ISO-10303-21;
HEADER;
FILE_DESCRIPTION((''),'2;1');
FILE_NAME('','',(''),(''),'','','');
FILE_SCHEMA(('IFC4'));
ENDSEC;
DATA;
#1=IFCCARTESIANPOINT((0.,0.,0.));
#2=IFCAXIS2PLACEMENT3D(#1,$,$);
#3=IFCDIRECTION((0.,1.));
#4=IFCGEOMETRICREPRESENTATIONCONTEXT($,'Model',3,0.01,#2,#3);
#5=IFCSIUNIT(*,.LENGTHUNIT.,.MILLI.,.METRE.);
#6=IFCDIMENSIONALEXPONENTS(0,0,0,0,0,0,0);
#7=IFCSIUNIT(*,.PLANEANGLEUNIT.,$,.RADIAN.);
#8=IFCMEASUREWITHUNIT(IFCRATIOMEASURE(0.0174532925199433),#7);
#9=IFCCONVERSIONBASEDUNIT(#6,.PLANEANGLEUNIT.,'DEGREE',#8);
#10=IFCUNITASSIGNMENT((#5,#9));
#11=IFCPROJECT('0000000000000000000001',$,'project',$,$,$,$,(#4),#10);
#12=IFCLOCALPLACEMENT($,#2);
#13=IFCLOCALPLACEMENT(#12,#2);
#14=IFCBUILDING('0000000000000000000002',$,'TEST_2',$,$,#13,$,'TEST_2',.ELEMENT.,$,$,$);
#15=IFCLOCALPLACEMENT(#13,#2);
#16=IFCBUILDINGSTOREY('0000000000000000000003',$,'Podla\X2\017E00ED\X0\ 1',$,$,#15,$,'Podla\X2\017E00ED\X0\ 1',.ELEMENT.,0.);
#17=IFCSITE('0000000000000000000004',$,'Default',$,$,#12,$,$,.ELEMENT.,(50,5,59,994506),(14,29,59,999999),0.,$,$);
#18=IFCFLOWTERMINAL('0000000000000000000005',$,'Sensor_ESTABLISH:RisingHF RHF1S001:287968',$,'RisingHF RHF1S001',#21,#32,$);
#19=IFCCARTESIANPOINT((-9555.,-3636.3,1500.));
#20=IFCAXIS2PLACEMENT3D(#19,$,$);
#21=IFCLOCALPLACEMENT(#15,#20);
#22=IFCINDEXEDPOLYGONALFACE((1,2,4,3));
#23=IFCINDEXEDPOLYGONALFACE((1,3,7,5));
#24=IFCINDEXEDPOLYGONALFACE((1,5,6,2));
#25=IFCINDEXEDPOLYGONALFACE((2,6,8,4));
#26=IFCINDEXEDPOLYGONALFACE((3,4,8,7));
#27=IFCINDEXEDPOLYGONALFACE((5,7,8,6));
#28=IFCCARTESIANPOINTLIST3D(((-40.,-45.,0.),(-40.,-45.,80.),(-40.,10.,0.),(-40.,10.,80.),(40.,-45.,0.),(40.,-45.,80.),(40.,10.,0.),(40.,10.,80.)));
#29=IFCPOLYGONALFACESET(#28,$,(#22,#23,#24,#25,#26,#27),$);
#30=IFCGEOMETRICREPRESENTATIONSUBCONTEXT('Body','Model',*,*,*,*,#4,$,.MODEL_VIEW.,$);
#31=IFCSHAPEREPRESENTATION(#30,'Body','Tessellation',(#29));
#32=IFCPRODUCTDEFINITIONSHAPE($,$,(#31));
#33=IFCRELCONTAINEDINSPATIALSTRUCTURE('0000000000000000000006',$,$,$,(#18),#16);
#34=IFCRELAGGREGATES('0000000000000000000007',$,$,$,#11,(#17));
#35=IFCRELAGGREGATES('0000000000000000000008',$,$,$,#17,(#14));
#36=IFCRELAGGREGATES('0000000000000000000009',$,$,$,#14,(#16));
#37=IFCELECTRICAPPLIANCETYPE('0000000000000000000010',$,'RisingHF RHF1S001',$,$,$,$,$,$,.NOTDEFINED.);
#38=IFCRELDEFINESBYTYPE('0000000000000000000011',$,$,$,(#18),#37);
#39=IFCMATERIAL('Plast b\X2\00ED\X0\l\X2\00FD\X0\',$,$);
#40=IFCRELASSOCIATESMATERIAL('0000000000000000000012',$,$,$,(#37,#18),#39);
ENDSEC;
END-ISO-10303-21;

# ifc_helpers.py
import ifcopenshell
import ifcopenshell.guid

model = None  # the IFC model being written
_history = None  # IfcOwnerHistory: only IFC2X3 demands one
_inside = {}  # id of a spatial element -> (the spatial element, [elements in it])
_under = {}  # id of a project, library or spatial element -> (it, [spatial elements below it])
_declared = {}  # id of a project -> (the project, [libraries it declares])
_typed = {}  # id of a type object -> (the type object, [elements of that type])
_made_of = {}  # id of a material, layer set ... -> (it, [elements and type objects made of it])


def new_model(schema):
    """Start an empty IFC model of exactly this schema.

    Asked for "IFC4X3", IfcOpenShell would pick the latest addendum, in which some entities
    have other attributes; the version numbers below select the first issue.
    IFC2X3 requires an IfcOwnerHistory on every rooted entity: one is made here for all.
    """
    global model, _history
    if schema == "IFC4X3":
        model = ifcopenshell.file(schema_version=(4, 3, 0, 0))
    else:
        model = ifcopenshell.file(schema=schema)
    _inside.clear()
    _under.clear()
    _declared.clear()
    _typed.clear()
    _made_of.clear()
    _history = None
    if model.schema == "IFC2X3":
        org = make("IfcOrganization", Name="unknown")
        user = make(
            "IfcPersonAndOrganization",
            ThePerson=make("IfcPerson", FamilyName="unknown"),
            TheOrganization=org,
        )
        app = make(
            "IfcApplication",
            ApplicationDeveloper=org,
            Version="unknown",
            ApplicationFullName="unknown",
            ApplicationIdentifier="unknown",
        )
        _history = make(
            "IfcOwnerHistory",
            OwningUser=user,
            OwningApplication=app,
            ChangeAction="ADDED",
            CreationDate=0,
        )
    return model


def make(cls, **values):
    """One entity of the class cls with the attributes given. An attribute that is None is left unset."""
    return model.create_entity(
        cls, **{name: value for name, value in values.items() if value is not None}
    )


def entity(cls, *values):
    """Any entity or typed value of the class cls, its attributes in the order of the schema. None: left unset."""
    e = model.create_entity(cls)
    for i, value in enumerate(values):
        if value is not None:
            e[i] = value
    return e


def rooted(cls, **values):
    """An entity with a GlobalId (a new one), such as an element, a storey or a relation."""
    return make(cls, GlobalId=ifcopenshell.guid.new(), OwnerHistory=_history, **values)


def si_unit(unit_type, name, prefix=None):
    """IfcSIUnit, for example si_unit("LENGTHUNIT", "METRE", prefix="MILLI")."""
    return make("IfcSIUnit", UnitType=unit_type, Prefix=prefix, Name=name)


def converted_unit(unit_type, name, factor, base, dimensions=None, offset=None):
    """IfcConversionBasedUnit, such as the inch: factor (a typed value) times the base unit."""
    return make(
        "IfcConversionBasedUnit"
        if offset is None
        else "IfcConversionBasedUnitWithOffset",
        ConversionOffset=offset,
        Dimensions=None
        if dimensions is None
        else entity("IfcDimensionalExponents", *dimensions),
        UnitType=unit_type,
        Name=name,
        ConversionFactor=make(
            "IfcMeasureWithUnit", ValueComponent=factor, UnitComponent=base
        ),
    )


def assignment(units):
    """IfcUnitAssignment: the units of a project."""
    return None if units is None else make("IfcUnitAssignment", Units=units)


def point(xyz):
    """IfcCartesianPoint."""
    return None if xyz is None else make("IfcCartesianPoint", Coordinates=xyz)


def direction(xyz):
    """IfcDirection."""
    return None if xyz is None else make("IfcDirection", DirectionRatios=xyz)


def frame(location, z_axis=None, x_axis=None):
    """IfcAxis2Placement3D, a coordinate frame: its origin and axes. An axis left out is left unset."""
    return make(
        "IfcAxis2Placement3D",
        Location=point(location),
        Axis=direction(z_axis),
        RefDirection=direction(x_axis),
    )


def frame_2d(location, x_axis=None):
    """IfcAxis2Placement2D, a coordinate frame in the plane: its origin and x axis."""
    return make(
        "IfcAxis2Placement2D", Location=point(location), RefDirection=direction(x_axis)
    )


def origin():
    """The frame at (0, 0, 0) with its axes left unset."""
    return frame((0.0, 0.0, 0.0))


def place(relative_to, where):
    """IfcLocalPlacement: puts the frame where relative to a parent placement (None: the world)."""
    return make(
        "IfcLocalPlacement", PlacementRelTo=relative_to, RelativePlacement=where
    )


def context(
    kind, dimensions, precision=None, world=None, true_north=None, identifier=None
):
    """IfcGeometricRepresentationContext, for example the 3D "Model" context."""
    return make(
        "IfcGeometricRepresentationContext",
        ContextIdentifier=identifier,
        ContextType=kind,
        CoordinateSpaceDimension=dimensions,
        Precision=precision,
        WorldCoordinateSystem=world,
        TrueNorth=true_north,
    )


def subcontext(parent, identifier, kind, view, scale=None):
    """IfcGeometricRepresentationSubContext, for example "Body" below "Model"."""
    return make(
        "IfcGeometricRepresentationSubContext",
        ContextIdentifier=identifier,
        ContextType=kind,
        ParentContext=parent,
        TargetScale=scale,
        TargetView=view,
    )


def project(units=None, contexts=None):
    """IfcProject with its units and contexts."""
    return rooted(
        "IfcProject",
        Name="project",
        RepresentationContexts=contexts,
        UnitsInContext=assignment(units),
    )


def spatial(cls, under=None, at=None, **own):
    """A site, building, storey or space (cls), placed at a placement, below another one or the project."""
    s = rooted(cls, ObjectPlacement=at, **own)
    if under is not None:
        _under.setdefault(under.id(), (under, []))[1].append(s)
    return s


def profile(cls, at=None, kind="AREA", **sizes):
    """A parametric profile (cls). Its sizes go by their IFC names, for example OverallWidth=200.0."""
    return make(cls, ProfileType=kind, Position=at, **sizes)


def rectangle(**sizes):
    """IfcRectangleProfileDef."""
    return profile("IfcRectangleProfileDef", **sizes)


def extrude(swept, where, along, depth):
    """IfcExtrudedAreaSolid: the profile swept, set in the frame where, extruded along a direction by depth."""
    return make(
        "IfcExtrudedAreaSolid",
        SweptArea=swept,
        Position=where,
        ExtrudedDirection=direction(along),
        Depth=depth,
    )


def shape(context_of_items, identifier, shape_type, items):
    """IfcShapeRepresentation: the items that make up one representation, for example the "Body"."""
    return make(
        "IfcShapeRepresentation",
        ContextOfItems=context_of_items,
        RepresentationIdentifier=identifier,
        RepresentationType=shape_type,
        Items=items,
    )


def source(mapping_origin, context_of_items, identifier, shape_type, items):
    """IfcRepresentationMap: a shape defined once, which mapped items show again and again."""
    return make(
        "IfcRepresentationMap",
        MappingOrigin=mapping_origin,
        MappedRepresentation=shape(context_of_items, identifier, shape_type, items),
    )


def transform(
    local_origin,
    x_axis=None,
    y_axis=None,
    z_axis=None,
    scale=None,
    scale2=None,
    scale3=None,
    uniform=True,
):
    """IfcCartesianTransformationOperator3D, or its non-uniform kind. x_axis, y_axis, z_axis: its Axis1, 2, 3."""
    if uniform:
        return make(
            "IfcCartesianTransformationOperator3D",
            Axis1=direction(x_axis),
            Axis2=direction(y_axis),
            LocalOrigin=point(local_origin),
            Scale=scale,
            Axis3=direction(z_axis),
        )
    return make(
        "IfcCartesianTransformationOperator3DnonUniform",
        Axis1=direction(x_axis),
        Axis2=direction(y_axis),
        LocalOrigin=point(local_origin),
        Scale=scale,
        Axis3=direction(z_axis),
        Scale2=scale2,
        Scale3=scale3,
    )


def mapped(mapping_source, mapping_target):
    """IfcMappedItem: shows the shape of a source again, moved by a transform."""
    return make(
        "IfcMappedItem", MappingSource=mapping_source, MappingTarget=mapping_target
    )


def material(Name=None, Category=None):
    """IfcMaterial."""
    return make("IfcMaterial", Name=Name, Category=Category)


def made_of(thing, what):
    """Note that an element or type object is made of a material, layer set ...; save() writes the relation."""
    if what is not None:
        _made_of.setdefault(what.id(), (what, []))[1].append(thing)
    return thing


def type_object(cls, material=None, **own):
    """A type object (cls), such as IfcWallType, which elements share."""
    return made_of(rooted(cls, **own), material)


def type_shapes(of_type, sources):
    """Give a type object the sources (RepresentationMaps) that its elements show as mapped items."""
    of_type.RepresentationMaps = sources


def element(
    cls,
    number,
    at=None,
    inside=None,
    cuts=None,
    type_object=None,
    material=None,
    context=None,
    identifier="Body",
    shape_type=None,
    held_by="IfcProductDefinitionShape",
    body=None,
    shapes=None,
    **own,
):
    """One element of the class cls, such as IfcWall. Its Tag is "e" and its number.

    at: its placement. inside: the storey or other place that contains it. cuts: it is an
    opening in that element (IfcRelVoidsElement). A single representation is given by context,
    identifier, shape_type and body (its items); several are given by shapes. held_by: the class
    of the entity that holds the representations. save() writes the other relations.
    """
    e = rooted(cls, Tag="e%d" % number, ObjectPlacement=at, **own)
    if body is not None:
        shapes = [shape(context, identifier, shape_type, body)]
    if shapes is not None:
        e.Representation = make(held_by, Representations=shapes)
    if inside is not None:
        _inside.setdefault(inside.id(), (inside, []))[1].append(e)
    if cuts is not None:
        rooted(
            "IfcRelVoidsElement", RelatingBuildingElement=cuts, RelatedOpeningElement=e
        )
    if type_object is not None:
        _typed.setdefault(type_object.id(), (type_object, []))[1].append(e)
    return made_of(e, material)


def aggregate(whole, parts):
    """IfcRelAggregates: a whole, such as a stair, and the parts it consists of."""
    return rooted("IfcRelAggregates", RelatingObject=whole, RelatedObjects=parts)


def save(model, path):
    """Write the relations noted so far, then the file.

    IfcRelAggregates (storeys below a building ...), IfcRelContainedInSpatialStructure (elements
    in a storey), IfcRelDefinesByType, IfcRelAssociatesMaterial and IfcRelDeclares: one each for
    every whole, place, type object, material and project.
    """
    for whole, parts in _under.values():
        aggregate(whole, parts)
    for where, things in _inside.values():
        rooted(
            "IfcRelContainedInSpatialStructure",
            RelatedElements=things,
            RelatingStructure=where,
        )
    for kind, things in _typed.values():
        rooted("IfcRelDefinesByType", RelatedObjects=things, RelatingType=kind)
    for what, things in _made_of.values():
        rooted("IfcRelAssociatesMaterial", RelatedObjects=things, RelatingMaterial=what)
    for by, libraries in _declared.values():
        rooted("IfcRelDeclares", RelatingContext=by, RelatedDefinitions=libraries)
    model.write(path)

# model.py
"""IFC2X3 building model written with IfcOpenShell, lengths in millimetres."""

from ifc_helpers import new_model, entity, si_unit, converted_unit, direction, frame, frame_2d, origin, place, context, subcontext, project, spatial, rectangle, extrude, source, transform, mapped, material, type_object, type_shapes, element, save


model = new_model("IFC2X3")

# Units and contexts
model_context = context("Model", 3, precision=0.01, world=origin(), true_north=direction((0.0, 1.0)))
body_context = subcontext(model_context, "Body", "Model", "MODEL_VIEW")
ifc_project = project(units=[si_unit("LENGTHUNIT", "METRE", prefix="MILLI"), converted_unit("PLANEANGLEUNIT", "DEGREE", entity("IfcRatioMeasure", 0.0174532925199433), si_unit("PLANEANGLEUNIT", "RADIAN"), dimensions=[0, 0, 0, 0, 0, 0, 0])], contexts=[model_context])

# Site, building, storey
site_placement = place(None, origin())
site = spatial("IfcSite", under=ifc_project, at=site_placement, Name="Default", CompositionType="ELEMENT", RefLatitude=(50, 5, 59, 994506), RefLongitude=(14, 29, 59, 999999), RefElevation=0.0)
building_placement = place(site_placement, origin())
building = spatial("IfcBuilding", under=site, at=building_placement, Name="TEST_2", LongName="TEST_2", CompositionType="ELEMENT")
storey_placement = place(building_placement, origin())
storey = spatial("IfcBuildingStorey", under=building, at=storey_placement, Name="Podlaží 1", LongName="Podlaží 1", CompositionType="ELEMENT", Elevation=0.0)

# Flow terminal
ifc_material_1 = material(Name="Plast bílý")
electric_appliance_type_1 = type_object("IfcElectricApplianceType", Name="RisingHF RHF1S001", PredefinedType="NOTDEFINED", material=ifc_material_1)
shared_shape_1 = source(origin(), body_context, "Body", "SweptSolid", [
    extrude(rectangle(XDim=80.0, YDim=55.0, at=frame_2d((0.0, 0.0), x_axis=(1.0, 0.0))), frame((0.0, -17.5, 0.0), z_axis=(0.0, 0.0, 1.0), x_axis=(-1.0, 0.0, 0.0)), (0.0, 0.0, 1.0), 80.0),
])
type_shapes(electric_appliance_type_1, [shared_shape_1])
flow_terminal_1_placement = place(storey_placement, frame((-9555.0, -3636.3, 1500.0)))
element("IfcFlowTerminal", 1, at=flow_terminal_1_placement, inside=storey, type_object=electric_appliance_type_1, material=ifc_material_1, Name="Sensor_ESTABLISH:RisingHF RHF1S001:287968", ObjectType="RisingHF RHF1S001", context=body_context, shape_type="MappedRepresentation", body=[
    mapped(shared_shape_1, transform((0.0, 0.0, 0.0), scale=1.0)),
])

save(model, "model.ifc")
